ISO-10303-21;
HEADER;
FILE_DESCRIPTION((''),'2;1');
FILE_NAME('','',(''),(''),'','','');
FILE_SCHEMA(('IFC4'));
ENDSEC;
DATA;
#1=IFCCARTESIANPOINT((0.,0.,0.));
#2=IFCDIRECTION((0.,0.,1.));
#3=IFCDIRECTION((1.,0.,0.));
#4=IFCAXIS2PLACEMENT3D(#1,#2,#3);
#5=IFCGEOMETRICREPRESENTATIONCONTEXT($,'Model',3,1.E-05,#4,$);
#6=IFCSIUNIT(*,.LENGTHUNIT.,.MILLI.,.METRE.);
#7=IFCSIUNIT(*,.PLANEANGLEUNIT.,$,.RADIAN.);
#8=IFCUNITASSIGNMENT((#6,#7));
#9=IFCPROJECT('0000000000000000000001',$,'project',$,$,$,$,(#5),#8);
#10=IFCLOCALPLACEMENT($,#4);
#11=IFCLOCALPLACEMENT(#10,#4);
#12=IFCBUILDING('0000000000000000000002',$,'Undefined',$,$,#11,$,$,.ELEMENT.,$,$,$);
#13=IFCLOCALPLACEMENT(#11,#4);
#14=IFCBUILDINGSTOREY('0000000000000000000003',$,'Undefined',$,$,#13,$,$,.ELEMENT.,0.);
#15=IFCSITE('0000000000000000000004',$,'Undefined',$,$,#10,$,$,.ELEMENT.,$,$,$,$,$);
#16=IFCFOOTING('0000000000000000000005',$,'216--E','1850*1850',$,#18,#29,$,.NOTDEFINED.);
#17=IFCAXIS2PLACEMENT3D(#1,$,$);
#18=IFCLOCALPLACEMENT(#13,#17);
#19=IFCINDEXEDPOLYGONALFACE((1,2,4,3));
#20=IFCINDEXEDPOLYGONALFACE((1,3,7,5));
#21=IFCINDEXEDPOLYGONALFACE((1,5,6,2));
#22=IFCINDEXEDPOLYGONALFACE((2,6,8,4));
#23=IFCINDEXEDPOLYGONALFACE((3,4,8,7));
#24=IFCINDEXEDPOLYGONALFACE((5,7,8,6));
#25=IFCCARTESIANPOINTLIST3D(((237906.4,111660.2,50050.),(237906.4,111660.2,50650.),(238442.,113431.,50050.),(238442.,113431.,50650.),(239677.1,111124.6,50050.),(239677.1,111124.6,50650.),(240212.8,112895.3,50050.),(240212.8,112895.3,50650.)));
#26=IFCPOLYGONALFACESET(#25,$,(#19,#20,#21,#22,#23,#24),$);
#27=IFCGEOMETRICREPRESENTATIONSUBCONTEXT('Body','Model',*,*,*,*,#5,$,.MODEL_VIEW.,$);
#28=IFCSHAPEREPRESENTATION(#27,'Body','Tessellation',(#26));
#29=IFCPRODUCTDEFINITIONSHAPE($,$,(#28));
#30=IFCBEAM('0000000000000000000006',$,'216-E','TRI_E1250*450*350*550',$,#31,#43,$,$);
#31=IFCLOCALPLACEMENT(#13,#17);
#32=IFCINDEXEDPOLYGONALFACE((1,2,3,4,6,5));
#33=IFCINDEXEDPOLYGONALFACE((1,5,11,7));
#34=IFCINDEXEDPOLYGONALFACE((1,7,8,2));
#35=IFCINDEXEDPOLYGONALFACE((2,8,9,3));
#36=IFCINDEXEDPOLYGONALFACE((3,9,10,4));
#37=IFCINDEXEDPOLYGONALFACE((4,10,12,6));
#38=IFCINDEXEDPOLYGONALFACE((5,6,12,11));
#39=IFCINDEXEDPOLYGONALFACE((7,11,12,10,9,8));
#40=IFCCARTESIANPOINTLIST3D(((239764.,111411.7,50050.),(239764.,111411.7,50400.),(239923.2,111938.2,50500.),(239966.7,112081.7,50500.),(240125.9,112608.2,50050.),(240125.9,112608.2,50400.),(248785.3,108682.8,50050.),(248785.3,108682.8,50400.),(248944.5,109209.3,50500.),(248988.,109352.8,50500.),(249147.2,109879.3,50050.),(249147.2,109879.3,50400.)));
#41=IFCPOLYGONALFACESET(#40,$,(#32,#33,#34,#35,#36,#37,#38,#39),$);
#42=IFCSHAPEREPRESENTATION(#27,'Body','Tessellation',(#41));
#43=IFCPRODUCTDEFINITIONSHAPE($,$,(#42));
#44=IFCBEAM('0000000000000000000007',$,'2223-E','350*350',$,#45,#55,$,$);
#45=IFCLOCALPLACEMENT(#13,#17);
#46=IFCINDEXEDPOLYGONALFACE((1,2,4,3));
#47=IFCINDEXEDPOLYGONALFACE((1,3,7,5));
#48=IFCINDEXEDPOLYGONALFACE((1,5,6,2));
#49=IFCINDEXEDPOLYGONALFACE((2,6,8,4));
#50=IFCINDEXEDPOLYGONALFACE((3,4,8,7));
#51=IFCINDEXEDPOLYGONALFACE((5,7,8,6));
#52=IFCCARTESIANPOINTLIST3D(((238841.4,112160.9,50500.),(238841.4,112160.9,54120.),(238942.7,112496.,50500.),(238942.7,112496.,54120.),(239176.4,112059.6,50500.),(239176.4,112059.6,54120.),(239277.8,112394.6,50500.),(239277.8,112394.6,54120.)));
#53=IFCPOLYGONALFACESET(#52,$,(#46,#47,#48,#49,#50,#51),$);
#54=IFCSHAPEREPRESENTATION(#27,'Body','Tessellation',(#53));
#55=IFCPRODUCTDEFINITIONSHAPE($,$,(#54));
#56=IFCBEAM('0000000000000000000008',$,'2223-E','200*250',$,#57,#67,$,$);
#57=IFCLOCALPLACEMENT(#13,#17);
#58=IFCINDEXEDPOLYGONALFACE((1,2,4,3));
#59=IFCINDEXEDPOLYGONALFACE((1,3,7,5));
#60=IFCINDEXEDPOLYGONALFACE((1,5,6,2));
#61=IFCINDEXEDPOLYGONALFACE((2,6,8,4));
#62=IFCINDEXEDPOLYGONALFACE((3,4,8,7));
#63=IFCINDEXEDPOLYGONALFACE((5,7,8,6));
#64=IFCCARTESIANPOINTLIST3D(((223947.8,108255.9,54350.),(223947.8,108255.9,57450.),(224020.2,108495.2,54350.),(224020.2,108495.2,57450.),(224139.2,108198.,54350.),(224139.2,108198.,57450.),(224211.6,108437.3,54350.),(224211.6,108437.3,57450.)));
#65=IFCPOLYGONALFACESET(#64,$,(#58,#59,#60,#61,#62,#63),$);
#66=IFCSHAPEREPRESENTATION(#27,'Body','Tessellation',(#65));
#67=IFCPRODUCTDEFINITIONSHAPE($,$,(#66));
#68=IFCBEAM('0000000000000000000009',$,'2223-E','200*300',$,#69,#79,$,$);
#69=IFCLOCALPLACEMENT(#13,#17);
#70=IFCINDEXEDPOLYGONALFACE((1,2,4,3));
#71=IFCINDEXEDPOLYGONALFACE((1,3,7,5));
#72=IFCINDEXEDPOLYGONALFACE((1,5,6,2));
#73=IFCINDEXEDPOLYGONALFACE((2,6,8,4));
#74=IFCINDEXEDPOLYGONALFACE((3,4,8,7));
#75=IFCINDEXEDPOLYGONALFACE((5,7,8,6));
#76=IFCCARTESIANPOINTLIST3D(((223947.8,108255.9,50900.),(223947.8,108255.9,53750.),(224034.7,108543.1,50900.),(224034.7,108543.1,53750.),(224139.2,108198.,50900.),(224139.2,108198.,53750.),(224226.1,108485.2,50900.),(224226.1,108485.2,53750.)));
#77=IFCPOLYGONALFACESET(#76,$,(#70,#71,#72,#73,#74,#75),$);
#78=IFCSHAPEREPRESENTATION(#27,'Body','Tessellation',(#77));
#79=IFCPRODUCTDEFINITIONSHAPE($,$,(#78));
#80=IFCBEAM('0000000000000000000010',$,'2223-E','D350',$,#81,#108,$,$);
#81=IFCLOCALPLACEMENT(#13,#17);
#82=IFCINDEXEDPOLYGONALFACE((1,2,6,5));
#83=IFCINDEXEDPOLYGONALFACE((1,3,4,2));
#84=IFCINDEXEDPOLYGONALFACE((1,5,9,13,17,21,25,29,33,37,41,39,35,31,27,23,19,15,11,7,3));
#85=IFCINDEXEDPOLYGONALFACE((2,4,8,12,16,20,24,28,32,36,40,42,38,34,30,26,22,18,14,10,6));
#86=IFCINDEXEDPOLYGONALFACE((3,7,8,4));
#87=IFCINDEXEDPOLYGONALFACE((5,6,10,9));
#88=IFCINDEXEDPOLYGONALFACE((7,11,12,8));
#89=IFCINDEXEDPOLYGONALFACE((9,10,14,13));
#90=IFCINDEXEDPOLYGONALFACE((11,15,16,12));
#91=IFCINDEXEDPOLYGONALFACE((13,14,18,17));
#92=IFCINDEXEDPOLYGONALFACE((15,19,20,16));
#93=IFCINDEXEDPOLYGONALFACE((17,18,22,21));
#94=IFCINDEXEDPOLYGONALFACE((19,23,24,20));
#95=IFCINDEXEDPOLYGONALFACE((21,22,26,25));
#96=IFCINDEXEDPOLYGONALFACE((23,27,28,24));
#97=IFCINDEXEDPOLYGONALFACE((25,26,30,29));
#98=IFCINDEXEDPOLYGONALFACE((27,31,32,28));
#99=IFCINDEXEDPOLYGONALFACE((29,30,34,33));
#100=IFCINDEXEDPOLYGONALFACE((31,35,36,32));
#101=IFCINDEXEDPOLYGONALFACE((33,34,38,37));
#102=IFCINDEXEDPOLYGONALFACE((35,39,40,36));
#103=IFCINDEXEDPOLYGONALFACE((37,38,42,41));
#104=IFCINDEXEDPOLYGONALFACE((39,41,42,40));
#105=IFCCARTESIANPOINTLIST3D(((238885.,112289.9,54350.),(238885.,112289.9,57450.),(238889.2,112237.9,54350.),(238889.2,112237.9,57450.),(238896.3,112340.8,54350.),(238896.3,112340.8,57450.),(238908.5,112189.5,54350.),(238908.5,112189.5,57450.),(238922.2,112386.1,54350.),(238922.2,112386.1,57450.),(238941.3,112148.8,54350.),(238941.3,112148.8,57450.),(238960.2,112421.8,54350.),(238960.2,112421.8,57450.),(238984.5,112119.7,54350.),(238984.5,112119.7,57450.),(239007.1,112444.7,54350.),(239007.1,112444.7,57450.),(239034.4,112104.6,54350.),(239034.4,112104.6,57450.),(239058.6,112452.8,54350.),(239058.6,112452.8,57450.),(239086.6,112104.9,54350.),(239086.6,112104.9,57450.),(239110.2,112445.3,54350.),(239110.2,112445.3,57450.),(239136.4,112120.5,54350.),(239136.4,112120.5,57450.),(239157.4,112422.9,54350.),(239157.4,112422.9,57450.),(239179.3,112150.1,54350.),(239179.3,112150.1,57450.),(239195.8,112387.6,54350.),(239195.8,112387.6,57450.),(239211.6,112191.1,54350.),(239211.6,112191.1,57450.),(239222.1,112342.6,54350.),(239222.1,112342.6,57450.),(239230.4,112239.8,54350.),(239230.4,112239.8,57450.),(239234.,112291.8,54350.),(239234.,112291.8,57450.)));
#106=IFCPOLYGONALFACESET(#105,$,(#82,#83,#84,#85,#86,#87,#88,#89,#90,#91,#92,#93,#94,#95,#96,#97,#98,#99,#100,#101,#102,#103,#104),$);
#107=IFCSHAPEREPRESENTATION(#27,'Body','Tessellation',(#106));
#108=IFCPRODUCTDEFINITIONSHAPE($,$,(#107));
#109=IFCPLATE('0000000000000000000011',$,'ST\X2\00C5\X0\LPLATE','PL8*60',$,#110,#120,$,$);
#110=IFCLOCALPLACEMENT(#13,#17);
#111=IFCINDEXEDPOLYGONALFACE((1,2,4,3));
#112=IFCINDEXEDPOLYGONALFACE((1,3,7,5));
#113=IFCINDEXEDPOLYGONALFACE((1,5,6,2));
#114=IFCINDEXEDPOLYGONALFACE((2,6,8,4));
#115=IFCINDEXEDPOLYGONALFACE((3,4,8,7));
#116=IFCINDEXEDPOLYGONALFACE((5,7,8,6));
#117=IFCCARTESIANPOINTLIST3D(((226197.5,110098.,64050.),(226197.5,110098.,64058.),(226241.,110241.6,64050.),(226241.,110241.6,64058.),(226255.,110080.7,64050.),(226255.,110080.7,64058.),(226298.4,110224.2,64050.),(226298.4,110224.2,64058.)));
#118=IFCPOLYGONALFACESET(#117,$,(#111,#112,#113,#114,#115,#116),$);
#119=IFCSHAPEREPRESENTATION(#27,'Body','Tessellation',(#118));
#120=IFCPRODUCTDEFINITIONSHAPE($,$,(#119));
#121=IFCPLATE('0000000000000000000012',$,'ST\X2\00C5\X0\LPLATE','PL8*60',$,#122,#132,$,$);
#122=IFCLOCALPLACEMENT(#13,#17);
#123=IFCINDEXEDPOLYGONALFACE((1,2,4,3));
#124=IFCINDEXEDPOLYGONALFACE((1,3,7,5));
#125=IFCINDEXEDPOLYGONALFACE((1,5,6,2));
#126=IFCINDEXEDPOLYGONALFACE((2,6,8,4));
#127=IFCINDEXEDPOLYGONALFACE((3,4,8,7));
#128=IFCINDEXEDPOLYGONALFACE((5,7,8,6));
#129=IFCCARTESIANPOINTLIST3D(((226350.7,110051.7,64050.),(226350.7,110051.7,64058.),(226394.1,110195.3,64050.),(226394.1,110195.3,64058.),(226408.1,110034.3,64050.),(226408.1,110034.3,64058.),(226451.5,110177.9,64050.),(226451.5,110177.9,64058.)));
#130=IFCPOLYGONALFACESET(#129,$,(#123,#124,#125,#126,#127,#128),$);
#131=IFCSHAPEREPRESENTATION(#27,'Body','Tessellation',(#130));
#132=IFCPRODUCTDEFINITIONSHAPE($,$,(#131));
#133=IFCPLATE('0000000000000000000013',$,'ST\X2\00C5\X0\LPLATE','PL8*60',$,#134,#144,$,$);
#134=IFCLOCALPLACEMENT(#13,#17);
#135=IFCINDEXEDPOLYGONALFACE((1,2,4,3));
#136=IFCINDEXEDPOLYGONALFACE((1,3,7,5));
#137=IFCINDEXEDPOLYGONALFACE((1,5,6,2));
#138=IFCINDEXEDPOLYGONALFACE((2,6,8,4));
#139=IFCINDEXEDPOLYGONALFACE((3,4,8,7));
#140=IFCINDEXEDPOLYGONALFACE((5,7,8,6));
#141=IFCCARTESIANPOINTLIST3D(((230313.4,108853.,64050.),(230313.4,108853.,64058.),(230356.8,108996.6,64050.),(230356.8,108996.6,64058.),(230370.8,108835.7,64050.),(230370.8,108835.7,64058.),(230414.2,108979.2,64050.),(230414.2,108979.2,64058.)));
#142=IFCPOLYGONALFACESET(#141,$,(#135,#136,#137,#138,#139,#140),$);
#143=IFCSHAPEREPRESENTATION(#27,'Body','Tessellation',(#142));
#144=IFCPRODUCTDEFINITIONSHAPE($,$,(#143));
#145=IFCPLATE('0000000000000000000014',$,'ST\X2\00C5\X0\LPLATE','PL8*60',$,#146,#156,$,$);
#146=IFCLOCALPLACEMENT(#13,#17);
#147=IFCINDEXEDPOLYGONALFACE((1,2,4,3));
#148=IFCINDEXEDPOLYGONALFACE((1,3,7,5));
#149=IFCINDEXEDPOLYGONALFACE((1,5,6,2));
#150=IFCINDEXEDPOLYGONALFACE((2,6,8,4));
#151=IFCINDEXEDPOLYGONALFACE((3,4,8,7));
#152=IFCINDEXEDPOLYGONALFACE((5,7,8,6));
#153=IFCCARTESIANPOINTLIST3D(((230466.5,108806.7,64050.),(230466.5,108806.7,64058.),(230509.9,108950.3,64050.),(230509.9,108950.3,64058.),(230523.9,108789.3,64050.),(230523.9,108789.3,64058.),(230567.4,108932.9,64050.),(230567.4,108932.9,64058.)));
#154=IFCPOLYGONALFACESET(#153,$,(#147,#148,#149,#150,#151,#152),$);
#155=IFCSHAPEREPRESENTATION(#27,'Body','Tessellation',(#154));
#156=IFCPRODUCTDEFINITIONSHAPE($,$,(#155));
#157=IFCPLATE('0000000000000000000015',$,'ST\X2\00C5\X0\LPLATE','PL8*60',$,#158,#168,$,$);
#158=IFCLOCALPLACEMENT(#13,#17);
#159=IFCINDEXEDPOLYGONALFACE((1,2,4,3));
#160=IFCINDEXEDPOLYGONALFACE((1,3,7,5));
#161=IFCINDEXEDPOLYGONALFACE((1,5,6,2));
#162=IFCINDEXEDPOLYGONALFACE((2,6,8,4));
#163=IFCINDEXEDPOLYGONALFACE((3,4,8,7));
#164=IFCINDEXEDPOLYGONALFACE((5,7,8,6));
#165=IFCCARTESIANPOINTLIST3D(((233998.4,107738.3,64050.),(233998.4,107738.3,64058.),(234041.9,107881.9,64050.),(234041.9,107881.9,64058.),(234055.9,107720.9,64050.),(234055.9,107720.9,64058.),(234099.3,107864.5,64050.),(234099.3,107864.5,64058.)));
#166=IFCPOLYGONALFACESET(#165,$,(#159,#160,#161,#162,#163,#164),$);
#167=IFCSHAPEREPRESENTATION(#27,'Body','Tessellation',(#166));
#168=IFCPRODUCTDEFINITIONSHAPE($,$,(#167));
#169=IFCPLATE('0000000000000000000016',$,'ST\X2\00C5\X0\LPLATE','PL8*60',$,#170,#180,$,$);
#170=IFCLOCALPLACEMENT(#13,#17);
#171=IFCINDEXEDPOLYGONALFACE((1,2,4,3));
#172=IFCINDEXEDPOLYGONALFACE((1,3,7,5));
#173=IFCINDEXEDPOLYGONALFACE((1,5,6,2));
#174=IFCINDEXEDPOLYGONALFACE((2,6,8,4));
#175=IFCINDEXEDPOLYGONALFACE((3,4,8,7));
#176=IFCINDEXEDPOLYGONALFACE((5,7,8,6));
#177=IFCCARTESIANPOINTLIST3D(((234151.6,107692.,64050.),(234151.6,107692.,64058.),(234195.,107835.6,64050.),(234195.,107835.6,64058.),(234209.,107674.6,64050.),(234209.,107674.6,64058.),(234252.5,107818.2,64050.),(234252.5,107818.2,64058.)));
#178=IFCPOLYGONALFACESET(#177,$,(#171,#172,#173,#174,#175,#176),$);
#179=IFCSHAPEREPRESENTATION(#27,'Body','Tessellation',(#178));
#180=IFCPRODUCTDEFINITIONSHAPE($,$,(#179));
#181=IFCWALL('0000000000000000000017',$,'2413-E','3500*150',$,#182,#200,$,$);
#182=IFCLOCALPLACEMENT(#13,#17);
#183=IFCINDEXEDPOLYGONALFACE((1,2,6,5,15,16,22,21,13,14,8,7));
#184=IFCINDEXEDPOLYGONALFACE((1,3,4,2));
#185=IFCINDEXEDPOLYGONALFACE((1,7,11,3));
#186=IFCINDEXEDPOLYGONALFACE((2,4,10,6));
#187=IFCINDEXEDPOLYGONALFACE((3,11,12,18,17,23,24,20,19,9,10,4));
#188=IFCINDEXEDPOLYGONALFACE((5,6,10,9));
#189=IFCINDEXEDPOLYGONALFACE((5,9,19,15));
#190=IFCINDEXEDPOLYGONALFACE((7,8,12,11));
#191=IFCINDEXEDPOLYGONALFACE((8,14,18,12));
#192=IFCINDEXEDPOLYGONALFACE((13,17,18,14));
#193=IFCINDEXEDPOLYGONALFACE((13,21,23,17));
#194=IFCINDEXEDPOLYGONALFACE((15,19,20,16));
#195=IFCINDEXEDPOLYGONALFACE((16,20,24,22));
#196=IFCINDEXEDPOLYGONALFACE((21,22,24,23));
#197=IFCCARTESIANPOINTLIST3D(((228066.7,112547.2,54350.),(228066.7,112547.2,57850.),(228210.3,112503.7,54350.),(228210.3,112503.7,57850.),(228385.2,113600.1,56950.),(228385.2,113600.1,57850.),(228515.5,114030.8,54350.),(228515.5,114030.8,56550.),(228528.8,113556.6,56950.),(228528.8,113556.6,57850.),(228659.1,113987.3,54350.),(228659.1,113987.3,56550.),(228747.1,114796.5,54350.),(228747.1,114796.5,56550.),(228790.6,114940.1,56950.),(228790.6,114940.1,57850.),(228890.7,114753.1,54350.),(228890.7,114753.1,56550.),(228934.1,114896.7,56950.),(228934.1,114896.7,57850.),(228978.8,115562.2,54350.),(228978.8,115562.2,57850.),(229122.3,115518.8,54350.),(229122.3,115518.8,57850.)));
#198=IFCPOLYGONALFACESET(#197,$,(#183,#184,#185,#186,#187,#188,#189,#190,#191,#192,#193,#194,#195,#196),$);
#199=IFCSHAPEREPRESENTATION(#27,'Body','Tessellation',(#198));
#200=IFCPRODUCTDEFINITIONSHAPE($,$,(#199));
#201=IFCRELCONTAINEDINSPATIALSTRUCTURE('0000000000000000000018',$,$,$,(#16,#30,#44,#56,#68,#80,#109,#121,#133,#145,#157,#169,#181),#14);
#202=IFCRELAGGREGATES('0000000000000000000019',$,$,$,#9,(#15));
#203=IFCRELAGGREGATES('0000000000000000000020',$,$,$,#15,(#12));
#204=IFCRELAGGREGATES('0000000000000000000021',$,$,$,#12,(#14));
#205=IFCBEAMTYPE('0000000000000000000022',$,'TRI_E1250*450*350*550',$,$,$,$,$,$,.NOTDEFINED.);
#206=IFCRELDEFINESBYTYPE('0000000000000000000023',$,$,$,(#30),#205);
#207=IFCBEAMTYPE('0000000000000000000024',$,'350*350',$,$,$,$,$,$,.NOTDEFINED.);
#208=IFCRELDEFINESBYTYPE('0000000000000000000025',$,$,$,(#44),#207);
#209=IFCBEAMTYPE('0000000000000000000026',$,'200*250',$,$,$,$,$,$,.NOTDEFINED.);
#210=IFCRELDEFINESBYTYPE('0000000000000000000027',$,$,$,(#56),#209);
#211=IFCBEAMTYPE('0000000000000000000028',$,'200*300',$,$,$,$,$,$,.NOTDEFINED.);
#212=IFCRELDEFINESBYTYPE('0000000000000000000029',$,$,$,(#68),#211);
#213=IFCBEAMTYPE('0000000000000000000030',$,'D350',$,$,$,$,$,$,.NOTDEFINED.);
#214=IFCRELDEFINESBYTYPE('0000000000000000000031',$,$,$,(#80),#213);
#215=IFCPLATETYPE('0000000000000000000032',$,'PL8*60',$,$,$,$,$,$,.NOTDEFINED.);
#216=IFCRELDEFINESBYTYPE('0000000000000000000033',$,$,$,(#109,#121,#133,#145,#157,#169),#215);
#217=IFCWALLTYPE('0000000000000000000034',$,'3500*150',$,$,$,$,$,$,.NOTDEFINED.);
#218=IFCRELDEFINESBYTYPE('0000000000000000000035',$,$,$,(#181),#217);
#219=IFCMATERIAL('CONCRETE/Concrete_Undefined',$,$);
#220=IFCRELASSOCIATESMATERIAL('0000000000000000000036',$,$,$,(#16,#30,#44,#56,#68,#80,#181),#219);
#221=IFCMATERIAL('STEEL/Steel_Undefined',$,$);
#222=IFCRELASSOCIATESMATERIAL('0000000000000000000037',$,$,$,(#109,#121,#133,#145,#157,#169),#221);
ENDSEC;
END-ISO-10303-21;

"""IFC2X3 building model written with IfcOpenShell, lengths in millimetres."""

from ifc_helpers import new_model, si_unit, frame, frame_2d, origin_with_axes, origin_2d_with_axis, place, context, subcontext, project, spatial, polyline, rectangle, circle, outline, extrude, boolean, material, type_object, element, save


model = new_model("IFC2X3")

# Units and contexts
model_context = context("Model", 3, precision=1e-05, world=origin_with_axes())
body_context = subcontext(model_context, "Body", "Model", "MODEL_VIEW")
ifc_project = project(units=[si_unit("LENGTHUNIT", "METRE", prefix="MILLI"), si_unit("PLANEANGLEUNIT", "RADIAN")], contexts=[model_context])

# Site, building, storey
site_placement = place(None, origin_with_axes())
site = spatial("IfcSite", under=ifc_project, at=site_placement, Name="Undefined", CompositionType="ELEMENT")
building_placement = place(site_placement, origin_with_axes())
building = spatial("IfcBuilding", under=site, at=building_placement, Name="Undefined", CompositionType="ELEMENT")
storey_placement = place(building_placement, origin_with_axes())
storey = spatial("IfcBuildingStorey", under=building, at=storey_placement, Name="Undefined", CompositionType="ELEMENT", Elevation=0.0)

# Footing
ifc_material_1 = material(Name="CONCRETE/Concrete_Undefined")
footing_placement = place(storey_placement, frame((239059.6, 112277.8, 50050.0), z_axis=(0.289538, 0.957166, 0.0), x_axis=(0.0, 0.0, 1.0)))
element("IfcFooting", 1, at=footing_placement, inside=storey, material=ifc_material_1, Name="216--E", Description="1850*1850", PredefinedType="NOTDEFINED", context=body_context, shape_type="SweptSolid", body=[
    extrude(rectangle(XDim=1850.0, YDim=1850.0, at=origin_2d_with_axis()), frame((600.0, 0.0, 0.0), z_axis=(-1.0, 0.0, 0.0), x_axis=(0.0, -1.0, 0.0)), (0.0, 0.0, 1.0), 600.0),
])

# Beams
beam_type_1 = type_object("IfcBeamType", Name="TRI_E1250*450*350*550", PredefinedType="NOTDEFINED")
beam_1_placement = place(storey_placement, frame((239945.0, 112010.0, 50275.0), z_axis=(0.0, 0.0, 1.0), x_axis=(0.957167, -0.289538, 0.0)))
element("IfcBeam", 2, at=beam_1_placement, inside=storey, type_object=beam_type_1, material=ifc_material_1, Name="216-E", Description="TRI_E1250*450*350*550", context=body_context, shape_type="SweptSolid", body=[
    extrude(outline(polyline([(625.0, -225.0), (-625.0, -225.0), (-625.0, 125.0), (-75.0, 225.0), (75.0, 225.0), (625.0, 125.0), (625.0, -225.0)])), frame((9425.0, 0.0, 0.0), z_axis=(-1.0, 0.0, 0.0), x_axis=(0.0, -1.0, 0.0)), (0.0, 0.0, 1.0), 9425.0),
])
beam_type_2 = type_object("IfcBeamType", Name="350*350", PredefinedType="NOTDEFINED")
beam_2_placement = place(storey_placement, frame((239059.6, 112277.8, 50500.0), z_axis=(0.957167, -0.289538, 0.0), x_axis=(0.0, 0.0, 1.0)))
element("IfcBeam", 3, at=beam_2_placement, inside=storey, type_object=beam_type_2, material=ifc_material_1, Name="2223-E", Description="350*350", context=body_context, shape_type="SweptSolid", body=[
    extrude(rectangle(XDim=350.0, YDim=350.0, at=origin_2d_with_axis()), frame((3620.0, 0.0, 0.0), z_axis=(-1.0, 0.0, 0.0), x_axis=(0.0, -1.0, 0.0)), (0.0, 0.0, 1.0), 3620.0),
])
beam_type_3 = type_object("IfcBeamType", Name="200*250", PredefinedType="NOTDEFINED")
beam_3_placement = place(storey_placement, frame((224079.7, 108346.6, 54350.0), z_axis=(0.957167, -0.289538, 0.0), x_axis=(0.0, 0.0, 1.0)))
element("IfcBeam", 4, at=beam_3_placement, inside=storey, type_object=beam_type_3, material=ifc_material_1, Name="2223-E", Description="200*250", context=body_context, shape_type="SweptSolid", body=[
    extrude(rectangle(XDim=250.0, YDim=200.0, at=origin_2d_with_axis()), frame((3100.0, 0.0, 0.0), z_axis=(-1.0, 0.0, 0.0), x_axis=(0.0, -1.0, 0.0)), (0.0, 0.0, 1.0), 3100.0),
])
beam_type_4 = type_object("IfcBeamType", Name="200*300", PredefinedType="NOTDEFINED")
beam_4_placement = place(storey_placement, frame((224087.0, 108370.6, 50900.0), z_axis=(0.957167, -0.289538, 0.0), x_axis=(0.0, 0.0, 1.0)))
element("IfcBeam", 5, at=beam_4_placement, inside=storey, type_object=beam_type_4, material=ifc_material_1, Name="2223-E", Description="200*300", context=body_context, shape_type="SweptSolid", body=[
    extrude(rectangle(XDim=300.0, YDim=200.0, at=origin_2d_with_axis()), frame((2850.0, 0.0, 0.0), z_axis=(-1.0, 0.0, 0.0), x_axis=(0.0, -1.0, 0.0)), (0.0, 0.0, 1.0), 2850.0),
])
beam_type_5 = type_object("IfcBeamType", Name="D350", PredefinedType="NOTDEFINED")
beam_5_placement = place(storey_placement, frame((239059.6, 112277.8, 54350.0), z_axis=(0.957167, -0.289538, 0.0), x_axis=(0.0, 0.0, 1.0)))
element("IfcBeam", 6, at=beam_5_placement, inside=storey, type_object=beam_type_5, material=ifc_material_1, Name="2223-E", Description="D350", context=body_context, shape_type="SweptSolid", body=[
    extrude(circle(Radius=175.0, at=origin_2d_with_axis()), frame((3100.0, 0.0, 0.0), z_axis=(-1.0, 0.0, 0.0), x_axis=(0.0, -1.0, 0.0)), (0.0, 0.0, 1.0), 3100.0),
])

# Plates
ifc_material_2 = material(Name="STEEL/Steel_Undefined")
plate_type = type_object("IfcPlateType", Name="PL8*60", PredefinedType="NOTDEFINED")
for number, where, z_axis, x_axis, name in (
    (7, (226298.4, 110224.2, 64054.0), (0.0, 0.0, -1.0), (-0.289538, -0.957167, 0.0), "STÅLPLATE"),
    (8, (226394.1, 110195.3, 64054.0), (0.0, 0.0, 1.0), (-0.289538, -0.957167, 0.0), "STÅLPLATE"),
    (9, (230414.2, 108979.2, 64054.0), (0.0, 0.0, -1.0), (-0.289538, -0.957167, 0.0), "STÅLPLATE"),
    (10, (230509.9, 108950.3, 64054.0), (0.0, 0.0, 1.0), (-0.289538, -0.957167, 0.0), "STÅLPLATE"),
    (11, (234099.3, 107864.5, 64054.0), (0.0, 0.0, -1.0), (-0.289538, -0.957167, 0.0), "STÅLPLATE"),
    (12, (234195.0, 107835.6, 64054.0), (0.0, 0.0, 1.0), (-0.289538, -0.957167, 0.0), "STÅLPLATE"),
):
    element("IfcPlate", number, at=place(storey_placement, frame(where, z_axis=z_axis, x_axis=x_axis)), inside=storey, type_object=plate_type, material=ifc_material_2, Name=name, Description="PL8*60", context=body_context, shape_type="SweptSolid", body=[
        extrude(outline(polyline([(0.0, 0.0), (150.0, 0.0), (150.0, 60.0), (0.0, 60.0), (0.0, 0.0)])), frame((0.0, 0.0, -4.0), z_axis=(0.0, 0.0, 1.0), x_axis=(1.0, 0.0, 0.0)), (0.0, 0.0, 1.0), 8.0),
    ])

# Wall
wall_type_1 = type_object("IfcWallType", Name="3500*150", PredefinedType="NOTDEFINED")
wall_1_placement = place(storey_placement, frame((228138.5, 112525.5, 54350.0), z_axis=(0.0, 0.0, 1.0), x_axis=(0.289536, 0.957167, 0.0)))
element("IfcWall", 13, at=wall_1_placement, inside=storey, type_object=wall_type_1, material=ifc_material_1, Name="2413-E", Description="3500*150", context=body_context, shape_type="CSG", body=[
    boolean("DIFFERENCE", boolean("DIFFERENCE", extrude(rectangle(XDim=3150.0, YDim=150.0, at=frame_2d((0.0, 1575.0), x_axis=(0.0, -1.0))), frame((0.0, 0.0, 0.0), z_axis=(0.0, 0.0, 1.0), x_axis=(0.0, -1.0, 0.0)), (0.0, 0.0, 1.0), 3500.0), extrude(rectangle(XDim=1400.0, YDim=200.0, at=frame_2d((0.0, 700.0), x_axis=(0.0, -1.0))), frame((2500.0, -25.0, 2600.0), z_axis=(0.0, 0.0, 1.0), x_axis=(0.000003, 1.0, 0.0)), (0.0, 0.0, 1.0), 900.0)), extrude(rectangle(XDim=800.0, YDim=200.0, at=frame_2d((0.0, 400.0), x_axis=(0.0, -1.0))), frame((2350.0, -25.0, 0.0), z_axis=(0.0, 0.0, 1.0), x_axis=(0.000006, 1.0, 0.0)), (0.0, 0.0, 1.0), 2200.0)),
])

save(model, "model.ifc")
